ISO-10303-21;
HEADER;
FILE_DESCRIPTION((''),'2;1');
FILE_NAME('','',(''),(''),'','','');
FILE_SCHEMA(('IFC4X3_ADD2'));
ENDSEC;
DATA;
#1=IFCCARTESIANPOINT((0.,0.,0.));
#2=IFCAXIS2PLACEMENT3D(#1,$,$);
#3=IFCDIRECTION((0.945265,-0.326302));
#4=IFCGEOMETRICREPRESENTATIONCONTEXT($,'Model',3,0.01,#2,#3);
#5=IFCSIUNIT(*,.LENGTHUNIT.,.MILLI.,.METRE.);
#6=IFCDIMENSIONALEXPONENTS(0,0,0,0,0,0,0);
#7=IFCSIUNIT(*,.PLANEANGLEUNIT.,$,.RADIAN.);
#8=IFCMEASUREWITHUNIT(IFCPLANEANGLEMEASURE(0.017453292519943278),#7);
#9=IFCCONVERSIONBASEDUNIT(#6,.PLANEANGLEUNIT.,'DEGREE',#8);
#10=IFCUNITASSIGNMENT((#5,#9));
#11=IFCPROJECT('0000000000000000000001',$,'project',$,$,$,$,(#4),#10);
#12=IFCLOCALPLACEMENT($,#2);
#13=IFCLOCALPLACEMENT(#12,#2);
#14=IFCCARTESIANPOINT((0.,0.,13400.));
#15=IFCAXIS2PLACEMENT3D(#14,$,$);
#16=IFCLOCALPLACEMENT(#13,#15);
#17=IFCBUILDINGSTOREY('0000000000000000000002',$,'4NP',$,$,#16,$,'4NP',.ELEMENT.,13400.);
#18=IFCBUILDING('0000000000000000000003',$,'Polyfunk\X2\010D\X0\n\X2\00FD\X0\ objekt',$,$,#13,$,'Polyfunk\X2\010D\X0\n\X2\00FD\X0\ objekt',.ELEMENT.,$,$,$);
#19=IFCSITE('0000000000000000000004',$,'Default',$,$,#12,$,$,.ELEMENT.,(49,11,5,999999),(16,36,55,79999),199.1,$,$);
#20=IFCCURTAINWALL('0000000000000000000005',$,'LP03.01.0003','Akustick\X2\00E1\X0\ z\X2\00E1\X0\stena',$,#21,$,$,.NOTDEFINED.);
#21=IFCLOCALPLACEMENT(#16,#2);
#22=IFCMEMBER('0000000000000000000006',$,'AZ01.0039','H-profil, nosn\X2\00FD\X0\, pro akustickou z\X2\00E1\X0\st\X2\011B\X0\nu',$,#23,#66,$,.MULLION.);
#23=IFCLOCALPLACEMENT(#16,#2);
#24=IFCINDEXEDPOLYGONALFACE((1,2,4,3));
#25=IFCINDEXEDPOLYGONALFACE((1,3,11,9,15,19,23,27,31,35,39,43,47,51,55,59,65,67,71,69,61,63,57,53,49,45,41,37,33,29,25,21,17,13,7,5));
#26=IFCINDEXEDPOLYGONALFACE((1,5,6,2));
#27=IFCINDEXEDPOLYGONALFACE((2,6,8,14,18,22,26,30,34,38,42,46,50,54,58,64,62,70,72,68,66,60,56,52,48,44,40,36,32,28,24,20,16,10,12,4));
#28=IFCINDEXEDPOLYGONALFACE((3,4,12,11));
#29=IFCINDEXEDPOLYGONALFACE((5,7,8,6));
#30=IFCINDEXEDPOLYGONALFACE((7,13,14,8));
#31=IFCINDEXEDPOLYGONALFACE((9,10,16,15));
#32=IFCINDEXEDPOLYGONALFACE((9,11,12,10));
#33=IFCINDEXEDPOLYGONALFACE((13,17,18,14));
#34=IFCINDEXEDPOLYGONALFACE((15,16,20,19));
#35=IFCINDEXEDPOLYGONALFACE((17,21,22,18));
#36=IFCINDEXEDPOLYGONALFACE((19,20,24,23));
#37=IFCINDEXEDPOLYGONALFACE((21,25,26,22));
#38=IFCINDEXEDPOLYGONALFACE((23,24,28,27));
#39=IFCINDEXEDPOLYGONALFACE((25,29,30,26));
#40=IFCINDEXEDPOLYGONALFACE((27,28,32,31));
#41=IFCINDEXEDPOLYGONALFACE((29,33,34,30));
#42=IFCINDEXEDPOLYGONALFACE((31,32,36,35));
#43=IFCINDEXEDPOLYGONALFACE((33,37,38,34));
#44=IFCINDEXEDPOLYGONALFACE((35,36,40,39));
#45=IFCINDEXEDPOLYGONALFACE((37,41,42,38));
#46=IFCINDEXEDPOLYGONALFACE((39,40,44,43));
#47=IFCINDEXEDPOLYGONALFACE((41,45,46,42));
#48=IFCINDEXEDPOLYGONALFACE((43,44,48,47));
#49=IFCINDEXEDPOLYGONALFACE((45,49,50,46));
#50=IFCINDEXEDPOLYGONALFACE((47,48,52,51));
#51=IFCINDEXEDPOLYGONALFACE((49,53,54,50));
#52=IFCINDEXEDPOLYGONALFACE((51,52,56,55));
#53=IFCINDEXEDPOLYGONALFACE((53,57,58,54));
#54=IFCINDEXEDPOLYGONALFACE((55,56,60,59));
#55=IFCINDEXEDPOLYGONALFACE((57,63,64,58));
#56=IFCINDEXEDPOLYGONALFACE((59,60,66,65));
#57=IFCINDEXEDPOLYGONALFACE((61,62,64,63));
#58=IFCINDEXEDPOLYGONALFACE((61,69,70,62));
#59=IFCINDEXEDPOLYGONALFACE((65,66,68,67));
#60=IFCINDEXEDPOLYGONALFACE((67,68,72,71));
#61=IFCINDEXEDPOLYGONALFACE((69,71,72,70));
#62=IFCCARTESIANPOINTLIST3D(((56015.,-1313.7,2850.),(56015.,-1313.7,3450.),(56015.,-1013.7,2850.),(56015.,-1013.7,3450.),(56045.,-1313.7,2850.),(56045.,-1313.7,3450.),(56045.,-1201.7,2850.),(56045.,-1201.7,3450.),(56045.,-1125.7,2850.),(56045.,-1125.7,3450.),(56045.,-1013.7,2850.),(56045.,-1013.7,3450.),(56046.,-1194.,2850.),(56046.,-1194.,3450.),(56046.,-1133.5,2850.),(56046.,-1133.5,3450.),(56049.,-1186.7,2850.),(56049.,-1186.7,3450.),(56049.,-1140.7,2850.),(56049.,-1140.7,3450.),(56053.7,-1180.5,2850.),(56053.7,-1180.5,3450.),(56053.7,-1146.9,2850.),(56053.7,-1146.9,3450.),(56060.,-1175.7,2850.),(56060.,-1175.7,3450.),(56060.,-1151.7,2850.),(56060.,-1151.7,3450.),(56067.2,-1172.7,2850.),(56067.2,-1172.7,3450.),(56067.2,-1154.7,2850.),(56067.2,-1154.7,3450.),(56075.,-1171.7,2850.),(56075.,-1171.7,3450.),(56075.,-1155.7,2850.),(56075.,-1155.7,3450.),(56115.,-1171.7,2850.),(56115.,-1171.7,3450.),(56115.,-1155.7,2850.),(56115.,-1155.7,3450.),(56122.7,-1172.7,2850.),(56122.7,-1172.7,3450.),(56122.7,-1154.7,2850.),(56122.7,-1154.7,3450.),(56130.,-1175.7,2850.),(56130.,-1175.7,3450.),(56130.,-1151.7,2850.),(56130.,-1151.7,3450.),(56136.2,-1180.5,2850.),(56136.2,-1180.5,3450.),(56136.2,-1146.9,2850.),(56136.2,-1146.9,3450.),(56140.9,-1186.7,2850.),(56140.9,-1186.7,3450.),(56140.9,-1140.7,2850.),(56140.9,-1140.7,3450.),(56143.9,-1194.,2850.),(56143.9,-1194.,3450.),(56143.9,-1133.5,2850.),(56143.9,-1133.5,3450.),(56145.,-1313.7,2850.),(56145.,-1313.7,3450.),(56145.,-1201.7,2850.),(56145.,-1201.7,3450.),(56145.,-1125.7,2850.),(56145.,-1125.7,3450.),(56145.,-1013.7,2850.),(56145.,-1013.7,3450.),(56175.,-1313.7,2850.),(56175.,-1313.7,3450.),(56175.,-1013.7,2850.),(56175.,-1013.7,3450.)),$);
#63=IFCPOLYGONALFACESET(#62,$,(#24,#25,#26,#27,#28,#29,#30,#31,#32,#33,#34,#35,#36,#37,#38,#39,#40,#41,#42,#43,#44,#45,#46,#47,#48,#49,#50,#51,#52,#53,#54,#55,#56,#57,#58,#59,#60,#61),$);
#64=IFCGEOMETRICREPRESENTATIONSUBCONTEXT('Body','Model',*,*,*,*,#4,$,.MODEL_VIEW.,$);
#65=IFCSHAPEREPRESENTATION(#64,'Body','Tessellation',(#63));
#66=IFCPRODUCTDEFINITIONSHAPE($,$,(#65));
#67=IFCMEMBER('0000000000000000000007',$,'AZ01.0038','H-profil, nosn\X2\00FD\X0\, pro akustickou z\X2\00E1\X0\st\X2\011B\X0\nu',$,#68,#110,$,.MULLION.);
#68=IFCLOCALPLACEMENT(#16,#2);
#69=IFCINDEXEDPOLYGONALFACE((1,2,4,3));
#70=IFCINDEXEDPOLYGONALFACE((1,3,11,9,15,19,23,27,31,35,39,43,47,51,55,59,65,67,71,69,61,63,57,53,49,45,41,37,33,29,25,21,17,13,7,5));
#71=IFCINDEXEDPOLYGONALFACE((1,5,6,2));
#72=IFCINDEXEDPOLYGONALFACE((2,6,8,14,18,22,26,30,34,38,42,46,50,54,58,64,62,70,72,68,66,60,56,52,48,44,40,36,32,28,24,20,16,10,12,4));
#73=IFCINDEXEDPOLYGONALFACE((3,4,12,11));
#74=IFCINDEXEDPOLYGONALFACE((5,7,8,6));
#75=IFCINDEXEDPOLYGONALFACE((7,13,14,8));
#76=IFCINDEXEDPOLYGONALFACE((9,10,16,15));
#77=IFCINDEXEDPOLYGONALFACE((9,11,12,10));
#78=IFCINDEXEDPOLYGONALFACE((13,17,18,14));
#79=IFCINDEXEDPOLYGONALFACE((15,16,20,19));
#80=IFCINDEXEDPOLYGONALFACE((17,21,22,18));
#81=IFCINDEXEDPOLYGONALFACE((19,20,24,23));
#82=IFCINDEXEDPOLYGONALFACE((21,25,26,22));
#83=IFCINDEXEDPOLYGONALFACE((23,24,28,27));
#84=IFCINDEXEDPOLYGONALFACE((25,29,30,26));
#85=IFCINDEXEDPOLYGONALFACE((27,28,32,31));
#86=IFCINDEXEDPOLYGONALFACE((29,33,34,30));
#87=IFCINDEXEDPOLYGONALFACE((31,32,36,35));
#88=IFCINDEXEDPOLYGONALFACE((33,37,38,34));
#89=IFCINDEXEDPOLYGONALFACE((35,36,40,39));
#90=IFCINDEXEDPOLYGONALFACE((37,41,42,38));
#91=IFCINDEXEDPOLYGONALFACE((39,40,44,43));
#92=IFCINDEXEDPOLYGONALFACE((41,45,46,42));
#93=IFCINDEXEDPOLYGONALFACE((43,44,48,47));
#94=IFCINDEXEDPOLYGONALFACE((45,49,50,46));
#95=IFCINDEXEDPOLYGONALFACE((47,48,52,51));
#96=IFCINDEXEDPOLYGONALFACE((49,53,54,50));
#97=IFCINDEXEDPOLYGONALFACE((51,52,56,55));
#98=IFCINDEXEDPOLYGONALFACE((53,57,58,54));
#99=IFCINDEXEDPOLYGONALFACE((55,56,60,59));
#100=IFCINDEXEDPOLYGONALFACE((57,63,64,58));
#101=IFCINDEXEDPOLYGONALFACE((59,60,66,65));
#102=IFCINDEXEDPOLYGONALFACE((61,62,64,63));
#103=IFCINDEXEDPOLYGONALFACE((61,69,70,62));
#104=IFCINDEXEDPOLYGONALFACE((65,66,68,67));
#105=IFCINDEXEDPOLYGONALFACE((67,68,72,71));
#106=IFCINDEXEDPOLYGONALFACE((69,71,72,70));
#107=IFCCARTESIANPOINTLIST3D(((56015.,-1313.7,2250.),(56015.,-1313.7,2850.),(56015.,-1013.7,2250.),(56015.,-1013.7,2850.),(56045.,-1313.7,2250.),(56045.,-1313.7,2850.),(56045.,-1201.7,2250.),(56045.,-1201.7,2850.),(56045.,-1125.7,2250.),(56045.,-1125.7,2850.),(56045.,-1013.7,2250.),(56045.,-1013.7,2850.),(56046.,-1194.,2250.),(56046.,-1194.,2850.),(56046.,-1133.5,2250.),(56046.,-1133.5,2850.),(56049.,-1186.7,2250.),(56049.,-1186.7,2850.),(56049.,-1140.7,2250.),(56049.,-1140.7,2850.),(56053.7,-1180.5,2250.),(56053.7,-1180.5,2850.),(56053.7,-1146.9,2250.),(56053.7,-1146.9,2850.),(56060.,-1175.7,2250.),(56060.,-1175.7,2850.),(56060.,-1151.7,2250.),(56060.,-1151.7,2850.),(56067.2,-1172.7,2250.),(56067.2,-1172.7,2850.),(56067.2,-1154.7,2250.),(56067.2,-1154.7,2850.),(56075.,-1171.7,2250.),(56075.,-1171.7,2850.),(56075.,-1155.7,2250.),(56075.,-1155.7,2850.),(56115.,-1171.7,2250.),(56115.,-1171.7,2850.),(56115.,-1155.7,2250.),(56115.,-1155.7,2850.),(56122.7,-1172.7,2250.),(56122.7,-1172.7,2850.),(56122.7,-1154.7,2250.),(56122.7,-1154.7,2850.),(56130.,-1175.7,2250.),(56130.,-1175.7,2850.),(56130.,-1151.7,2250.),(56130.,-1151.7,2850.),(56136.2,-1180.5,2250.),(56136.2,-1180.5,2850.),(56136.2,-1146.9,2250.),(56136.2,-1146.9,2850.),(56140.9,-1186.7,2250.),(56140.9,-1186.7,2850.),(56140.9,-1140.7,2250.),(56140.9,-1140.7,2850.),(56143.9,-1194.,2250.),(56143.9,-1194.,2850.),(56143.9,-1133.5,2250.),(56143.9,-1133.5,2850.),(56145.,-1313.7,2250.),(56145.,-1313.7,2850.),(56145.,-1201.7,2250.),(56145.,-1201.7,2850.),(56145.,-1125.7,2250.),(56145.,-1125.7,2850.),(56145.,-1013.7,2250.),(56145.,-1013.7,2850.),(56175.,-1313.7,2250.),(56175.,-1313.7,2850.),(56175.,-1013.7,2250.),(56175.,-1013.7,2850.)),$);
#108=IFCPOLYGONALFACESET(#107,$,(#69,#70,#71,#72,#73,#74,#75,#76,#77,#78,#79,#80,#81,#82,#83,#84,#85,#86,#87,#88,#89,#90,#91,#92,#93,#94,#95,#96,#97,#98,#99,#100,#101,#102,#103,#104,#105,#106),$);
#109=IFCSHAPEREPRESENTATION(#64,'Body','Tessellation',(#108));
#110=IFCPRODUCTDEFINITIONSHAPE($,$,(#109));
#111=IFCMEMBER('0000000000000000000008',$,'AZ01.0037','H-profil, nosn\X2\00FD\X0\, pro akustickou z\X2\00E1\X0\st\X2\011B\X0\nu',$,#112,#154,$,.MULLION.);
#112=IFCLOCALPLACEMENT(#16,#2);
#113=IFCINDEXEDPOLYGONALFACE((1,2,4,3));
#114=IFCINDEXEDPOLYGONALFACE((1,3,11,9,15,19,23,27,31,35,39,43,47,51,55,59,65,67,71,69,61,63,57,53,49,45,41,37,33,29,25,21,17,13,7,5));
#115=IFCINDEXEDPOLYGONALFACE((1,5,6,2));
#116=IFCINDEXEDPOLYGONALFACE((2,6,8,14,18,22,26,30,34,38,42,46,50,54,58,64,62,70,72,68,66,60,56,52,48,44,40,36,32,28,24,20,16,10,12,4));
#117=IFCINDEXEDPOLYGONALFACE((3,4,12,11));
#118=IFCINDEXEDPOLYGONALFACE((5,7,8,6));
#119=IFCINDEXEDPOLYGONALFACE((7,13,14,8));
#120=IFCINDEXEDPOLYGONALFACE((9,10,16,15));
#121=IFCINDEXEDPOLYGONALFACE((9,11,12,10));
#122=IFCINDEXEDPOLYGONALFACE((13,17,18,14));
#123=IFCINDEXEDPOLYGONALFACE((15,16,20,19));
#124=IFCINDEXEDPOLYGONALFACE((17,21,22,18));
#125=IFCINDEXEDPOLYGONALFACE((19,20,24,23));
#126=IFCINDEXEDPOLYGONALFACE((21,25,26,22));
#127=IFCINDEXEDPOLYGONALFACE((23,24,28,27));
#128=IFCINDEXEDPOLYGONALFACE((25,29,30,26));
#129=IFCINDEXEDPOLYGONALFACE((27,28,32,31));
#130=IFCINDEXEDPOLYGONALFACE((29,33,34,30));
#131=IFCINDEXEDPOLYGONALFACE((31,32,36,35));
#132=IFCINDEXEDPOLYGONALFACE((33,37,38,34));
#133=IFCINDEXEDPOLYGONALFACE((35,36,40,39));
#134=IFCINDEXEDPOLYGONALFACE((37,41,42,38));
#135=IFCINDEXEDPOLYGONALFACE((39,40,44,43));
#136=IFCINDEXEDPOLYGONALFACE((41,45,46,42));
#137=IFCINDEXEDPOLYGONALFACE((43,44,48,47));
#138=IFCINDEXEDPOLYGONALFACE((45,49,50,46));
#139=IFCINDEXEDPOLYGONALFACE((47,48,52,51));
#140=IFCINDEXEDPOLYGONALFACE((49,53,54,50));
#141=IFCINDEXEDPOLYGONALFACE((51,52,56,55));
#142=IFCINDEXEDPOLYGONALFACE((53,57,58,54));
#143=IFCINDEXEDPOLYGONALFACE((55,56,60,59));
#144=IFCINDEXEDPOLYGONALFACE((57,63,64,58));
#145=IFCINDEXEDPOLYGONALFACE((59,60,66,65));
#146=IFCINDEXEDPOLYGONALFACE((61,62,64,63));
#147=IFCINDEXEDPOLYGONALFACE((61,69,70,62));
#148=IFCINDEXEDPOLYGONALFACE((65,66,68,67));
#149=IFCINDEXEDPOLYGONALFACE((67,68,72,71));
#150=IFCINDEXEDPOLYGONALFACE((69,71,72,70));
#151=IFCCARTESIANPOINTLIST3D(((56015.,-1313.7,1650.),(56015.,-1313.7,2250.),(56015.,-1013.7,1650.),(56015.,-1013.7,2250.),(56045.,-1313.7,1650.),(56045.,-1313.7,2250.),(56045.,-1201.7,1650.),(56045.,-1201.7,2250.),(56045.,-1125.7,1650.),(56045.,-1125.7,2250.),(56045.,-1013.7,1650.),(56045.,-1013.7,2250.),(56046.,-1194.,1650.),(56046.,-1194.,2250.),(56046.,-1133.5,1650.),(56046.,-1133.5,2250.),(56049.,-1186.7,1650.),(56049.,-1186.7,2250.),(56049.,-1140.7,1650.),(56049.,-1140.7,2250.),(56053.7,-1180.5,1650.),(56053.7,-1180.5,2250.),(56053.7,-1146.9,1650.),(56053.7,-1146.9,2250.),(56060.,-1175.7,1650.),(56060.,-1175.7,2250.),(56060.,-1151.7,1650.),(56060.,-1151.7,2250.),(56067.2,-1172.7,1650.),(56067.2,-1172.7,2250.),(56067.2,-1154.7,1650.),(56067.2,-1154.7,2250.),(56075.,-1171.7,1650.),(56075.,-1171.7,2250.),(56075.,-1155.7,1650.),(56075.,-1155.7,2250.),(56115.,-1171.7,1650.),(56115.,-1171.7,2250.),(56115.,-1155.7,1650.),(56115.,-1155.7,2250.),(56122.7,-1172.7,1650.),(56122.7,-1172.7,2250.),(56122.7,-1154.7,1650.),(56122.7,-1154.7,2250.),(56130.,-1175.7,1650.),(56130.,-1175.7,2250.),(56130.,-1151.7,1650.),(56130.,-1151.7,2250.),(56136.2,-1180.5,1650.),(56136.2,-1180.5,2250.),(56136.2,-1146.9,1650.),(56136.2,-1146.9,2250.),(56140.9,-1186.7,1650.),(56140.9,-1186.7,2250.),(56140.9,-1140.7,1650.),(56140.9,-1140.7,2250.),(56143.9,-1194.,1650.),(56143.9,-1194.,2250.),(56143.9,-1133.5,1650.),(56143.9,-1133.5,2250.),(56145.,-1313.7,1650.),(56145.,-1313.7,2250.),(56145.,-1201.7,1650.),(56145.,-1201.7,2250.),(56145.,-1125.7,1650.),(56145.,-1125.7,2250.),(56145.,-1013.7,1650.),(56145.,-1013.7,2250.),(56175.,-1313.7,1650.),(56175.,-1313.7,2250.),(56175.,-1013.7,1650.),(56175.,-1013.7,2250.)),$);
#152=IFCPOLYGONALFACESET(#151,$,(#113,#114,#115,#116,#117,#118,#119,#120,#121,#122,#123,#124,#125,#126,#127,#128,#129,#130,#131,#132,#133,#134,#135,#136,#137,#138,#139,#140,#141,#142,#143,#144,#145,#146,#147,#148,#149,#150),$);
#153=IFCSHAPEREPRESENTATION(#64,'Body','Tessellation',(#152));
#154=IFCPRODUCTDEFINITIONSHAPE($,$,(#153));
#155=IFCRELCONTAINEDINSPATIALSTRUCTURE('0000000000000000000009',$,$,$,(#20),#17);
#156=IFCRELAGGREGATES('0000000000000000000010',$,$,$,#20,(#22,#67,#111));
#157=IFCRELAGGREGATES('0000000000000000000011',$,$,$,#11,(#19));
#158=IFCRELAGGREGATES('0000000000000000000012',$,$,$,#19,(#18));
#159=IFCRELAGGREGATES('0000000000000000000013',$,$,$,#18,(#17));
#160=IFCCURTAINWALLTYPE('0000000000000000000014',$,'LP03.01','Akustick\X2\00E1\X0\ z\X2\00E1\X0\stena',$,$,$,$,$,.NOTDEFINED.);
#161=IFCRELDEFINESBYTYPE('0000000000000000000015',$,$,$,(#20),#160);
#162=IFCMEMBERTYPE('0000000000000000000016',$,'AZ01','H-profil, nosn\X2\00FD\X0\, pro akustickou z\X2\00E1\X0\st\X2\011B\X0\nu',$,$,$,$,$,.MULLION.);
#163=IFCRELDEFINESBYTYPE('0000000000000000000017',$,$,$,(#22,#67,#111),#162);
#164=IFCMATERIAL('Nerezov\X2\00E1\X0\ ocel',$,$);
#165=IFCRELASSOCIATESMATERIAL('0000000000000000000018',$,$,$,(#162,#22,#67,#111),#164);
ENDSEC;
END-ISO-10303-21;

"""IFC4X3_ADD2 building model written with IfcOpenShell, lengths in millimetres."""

from ifc_helpers import new_model, entity, si_unit, converted_unit, direction, frame, frame_2d, origin, place, context, subcontext, project, spatial, polyline, circle_curve, parameter, trimmed, segment, composite_curve, outline, extrude, source, transform, mapped, material, material_profile, profile_set, profile_usage, type_object, element, aggregate, save


model = new_model("IFC4X3_ADD2")

# Units and contexts
model_context = context("Model", 3, precision=0.01, world=origin(), true_north=direction((0.945265, -0.326302)))
body_context = subcontext(model_context, "Body", "Model", "MODEL_VIEW")
ifc_project = project(units=[si_unit("LENGTHUNIT", "METRE", prefix="MILLI"), converted_unit("PLANEANGLEUNIT", "DEGREE", entity("IfcPlaneAngleMeasure", 0.017453292519943278), si_unit("PLANEANGLEUNIT", "RADIAN"), dimensions=[0, 0, 0, 0, 0, 0, 0])], contexts=[model_context])

# Site, building, storey
site_placement = place(None, origin())
site = spatial("IfcSite", under=ifc_project, at=site_placement, Name="Default", CompositionType="ELEMENT", RefLatitude=(49, 11, 5, 999999), RefLongitude=(16, 36, 55, 79999), RefElevation=199.1)
building_placement = place(site_placement, origin())
building = spatial("IfcBuilding", under=site, at=building_placement, Name="Polyfunkčný objekt", LongName="Polyfunkčný objekt", CompositionType="ELEMENT")
storey_placement = place(building_placement, frame((0.0, 0.0, 13400.0)))
storey = spatial("IfcBuildingStorey", under=building, at=storey_placement, Name="4NP", LongName="4NP", CompositionType="ELEMENT", Elevation=13400.0)

# Curtain wall, members
curtain_wall_type = type_object("IfcCurtainWallType", Name="LP03.01", Description="Akustická zástena", PredefinedType="NOTDEFINED")
curtain_wall_placement = place(storey_placement, frame((0.0, 0.0, -13400.0)))
curtain_wall = element("IfcCurtainWall", 1, at=curtain_wall_placement, inside=storey, type_object=curtain_wall_type, Name="LP03.01.0003", Description="Akustická zástena", PredefinedType="NOTDEFINED")
ifc_material_1 = material(Name="Nerezová ocel")
ifc_material_profile = material_profile(ifc_material_1, outline(composite_curve([segment(polyline([(50.0, -150.0), (80.0, -150.0)]), True, "CONTINUOUS"), segment(polyline([(80.0, -150.0), (80.0, 150.0)]), True, "CONTINUOUS"), segment(polyline([(80.0, 150.0), (50.0, 150.0)]), True, "CONTINUOUS"), segment(polyline([(50.0, 150.0), (50.0, 38.0)]), True, "CONTINUOUS"), segment(trimmed(circle_curve(frame_2d((20.0, 38.0), x_axis=(0.0, 1.0)), 30.0), [parameter(180.0)], [parameter(270.0)], True, "PARAMETER"), False, "CONTINUOUS"), segment(polyline([(20.0, 8.0), (-20.0, 8.0)]), True, "CONTINUOUS"), segment(trimmed(circle_curve(frame_2d((-20.0, 38.0), x_axis=(0.0, 1.0)), 30.0), [parameter(90.0)], [parameter(180.0)], True, "PARAMETER"), False, "CONTINUOUS"), segment(polyline([(-50.0, 38.0), (-50.0, 150.0)]), True, "CONTINUOUS"), segment(polyline([(-50.0, 150.0), (-80.0, 150.0)]), True, "CONTINUOUS"), segment(polyline([(-80.0, 150.0), (-80.0, -150.0)]), True, "CONTINUOUS"), segment(polyline([(-80.0, -150.0), (-50.0, -150.0)]), True, "CONTINUOUS"), segment(polyline([(-50.0, -150.0), (-50.0, -38.0)]), True, "CONTINUOUS"), segment(trimmed(circle_curve(frame_2d((-20.0, -38.0), x_axis=(0.0, 1.0)), 30.0), [parameter(0.0)], [parameter(90.0)], True, "PARAMETER"), False, "CONTINUOUS"), segment(polyline([(-20.0, -8.0), (20.0, -8.0)]), True, "CONTINUOUS"), segment(trimmed(circle_curve(frame_2d((20.0, -38.0), x_axis=(0.0, 1.0)), 30.0), [parameter(270.0)], [parameter(0.0)], True, "PARAMETER"), False, "CONTINUOUS"), segment(polyline([(50.0, -38.0), (50.0, -150.0)]), True, "CONTINUOUS")], self_intersect=False)), Name="Profil zástena")
ifc_profile_set = profile_set([ifc_material_profile], Name="Profil zástena")
ifc_profile_usage = profile_usage(ifc_profile_set)
member_type = type_object("IfcMemberType", Name="AZ01", Description="H-profil, nosný, pro akustickou zástěnu", PredefinedType="MULLION", material=ifc_profile_set)
shared_shape_1 = source(origin(), body_context, "Body", "SweptSolid", [
    extrude(outline(composite_curve([segment(polyline([(50.0, -150.0), (80.0, -150.0)]), True, "CONTINUOUS"), segment(polyline([(80.0, -150.0), (80.0, 150.0)]), True, "CONTINUOUS"), segment(polyline([(80.0, 150.0), (50.0, 150.0)]), True, "CONTINUOUS"), segment(polyline([(50.0, 150.0), (50.0, 38.0)]), True, "CONTINUOUS"), segment(trimmed(circle_curve(frame_2d((20.0, 38.0), x_axis=(0.0, 1.0)), 30.0), [parameter(180.0)], [parameter(270.0)], True, "PARAMETER"), False, "CONTINUOUS"), segment(polyline([(20.0, 8.0), (-20.0, 8.0)]), True, "CONTINUOUS"), segment(trimmed(circle_curve(frame_2d((-20.0, 38.0), x_axis=(0.0, 1.0)), 30.0), [parameter(90.0)], [parameter(180.0)], True, "PARAMETER"), False, "CONTINUOUS"), segment(polyline([(-50.0, 38.0), (-50.0, 150.0)]), True, "CONTINUOUS"), segment(polyline([(-50.0, 150.0), (-80.0, 150.0)]), True, "CONTINUOUS"), segment(polyline([(-80.0, 150.0), (-80.0, -150.0)]), True, "CONTINUOUS"), segment(polyline([(-80.0, -150.0), (-50.0, -150.0)]), True, "CONTINUOUS"), segment(polyline([(-50.0, -150.0), (-50.0, -38.0)]), True, "CONTINUOUS"), segment(trimmed(circle_curve(frame_2d((-20.0, -38.0), x_axis=(0.0, 1.0)), 30.0), [parameter(0.0)], [parameter(90.0)], True, "PARAMETER"), False, "CONTINUOUS"), segment(polyline([(-20.0, -8.0), (20.0, -8.0)]), True, "CONTINUOUS"), segment(trimmed(circle_curve(frame_2d((20.0, -38.0), x_axis=(0.0, 1.0)), 30.0), [parameter(270.0)], [parameter(0.0)], True, "PARAMETER"), False, "CONTINUOUS"), segment(polyline([(50.0, -38.0), (50.0, -150.0)]), True, "CONTINUOUS")], self_intersect=False)), frame((-150.0, 0.0, -600.0), z_axis=(0.0, 0.0, 1.0), x_axis=(0.0, 1.0, 0.0)), (0.0, 0.0, 1.0), 600.0),
])
member_1_placement = place(curtain_wall_placement, frame((56095.0, -1313.7, 16850.0), z_axis=(0.0, 0.0, 1.0), x_axis=(0.0, -1.0, 0.0)))
member_1 = element("IfcMember", 2, at=member_1_placement, type_object=member_type, material=ifc_profile_usage, Name="AZ01.0039", Description="H-profil, nosný, pro akustickou zástěnu", PredefinedType="MULLION", context=body_context, shape_type="MappedRepresentation", body=[
    mapped(shared_shape_1, transform((0.0, 0.0, 0.0), scale=1.0)),
])
member_2_placement = place(curtain_wall_placement, frame((56095.0, -1313.7, 16250.0), z_axis=(0.0, 0.0, 1.0), x_axis=(0.0, -1.0, 0.0)))
member_2 = element("IfcMember", 3, at=member_2_placement, type_object=member_type, material=ifc_profile_usage, Name="AZ01.0038", Description="H-profil, nosný, pro akustickou zástěnu", PredefinedType="MULLION", context=body_context, shape_type="MappedRepresentation", body=[
    mapped(shared_shape_1, transform((0.0, 0.0, 0.0), scale=1.0)),
])
member_3_placement = place(curtain_wall_placement, frame((56095.0, -1313.7, 15650.0), z_axis=(0.0, 0.0, 1.0), x_axis=(0.0, -1.0, 0.0)))
member_3 = element("IfcMember", 4, at=member_3_placement, type_object=member_type, material=ifc_profile_usage, Name="AZ01.0037", Description="H-profil, nosný, pro akustickou zástěnu", PredefinedType="MULLION", context=body_context, shape_type="MappedRepresentation", body=[
    mapped(shared_shape_1, transform((0.0, 0.0, 0.0), scale=1.0)),
])
aggregate(curtain_wall, [member_1, member_2, member_3])

save(model, "model.ifc")
